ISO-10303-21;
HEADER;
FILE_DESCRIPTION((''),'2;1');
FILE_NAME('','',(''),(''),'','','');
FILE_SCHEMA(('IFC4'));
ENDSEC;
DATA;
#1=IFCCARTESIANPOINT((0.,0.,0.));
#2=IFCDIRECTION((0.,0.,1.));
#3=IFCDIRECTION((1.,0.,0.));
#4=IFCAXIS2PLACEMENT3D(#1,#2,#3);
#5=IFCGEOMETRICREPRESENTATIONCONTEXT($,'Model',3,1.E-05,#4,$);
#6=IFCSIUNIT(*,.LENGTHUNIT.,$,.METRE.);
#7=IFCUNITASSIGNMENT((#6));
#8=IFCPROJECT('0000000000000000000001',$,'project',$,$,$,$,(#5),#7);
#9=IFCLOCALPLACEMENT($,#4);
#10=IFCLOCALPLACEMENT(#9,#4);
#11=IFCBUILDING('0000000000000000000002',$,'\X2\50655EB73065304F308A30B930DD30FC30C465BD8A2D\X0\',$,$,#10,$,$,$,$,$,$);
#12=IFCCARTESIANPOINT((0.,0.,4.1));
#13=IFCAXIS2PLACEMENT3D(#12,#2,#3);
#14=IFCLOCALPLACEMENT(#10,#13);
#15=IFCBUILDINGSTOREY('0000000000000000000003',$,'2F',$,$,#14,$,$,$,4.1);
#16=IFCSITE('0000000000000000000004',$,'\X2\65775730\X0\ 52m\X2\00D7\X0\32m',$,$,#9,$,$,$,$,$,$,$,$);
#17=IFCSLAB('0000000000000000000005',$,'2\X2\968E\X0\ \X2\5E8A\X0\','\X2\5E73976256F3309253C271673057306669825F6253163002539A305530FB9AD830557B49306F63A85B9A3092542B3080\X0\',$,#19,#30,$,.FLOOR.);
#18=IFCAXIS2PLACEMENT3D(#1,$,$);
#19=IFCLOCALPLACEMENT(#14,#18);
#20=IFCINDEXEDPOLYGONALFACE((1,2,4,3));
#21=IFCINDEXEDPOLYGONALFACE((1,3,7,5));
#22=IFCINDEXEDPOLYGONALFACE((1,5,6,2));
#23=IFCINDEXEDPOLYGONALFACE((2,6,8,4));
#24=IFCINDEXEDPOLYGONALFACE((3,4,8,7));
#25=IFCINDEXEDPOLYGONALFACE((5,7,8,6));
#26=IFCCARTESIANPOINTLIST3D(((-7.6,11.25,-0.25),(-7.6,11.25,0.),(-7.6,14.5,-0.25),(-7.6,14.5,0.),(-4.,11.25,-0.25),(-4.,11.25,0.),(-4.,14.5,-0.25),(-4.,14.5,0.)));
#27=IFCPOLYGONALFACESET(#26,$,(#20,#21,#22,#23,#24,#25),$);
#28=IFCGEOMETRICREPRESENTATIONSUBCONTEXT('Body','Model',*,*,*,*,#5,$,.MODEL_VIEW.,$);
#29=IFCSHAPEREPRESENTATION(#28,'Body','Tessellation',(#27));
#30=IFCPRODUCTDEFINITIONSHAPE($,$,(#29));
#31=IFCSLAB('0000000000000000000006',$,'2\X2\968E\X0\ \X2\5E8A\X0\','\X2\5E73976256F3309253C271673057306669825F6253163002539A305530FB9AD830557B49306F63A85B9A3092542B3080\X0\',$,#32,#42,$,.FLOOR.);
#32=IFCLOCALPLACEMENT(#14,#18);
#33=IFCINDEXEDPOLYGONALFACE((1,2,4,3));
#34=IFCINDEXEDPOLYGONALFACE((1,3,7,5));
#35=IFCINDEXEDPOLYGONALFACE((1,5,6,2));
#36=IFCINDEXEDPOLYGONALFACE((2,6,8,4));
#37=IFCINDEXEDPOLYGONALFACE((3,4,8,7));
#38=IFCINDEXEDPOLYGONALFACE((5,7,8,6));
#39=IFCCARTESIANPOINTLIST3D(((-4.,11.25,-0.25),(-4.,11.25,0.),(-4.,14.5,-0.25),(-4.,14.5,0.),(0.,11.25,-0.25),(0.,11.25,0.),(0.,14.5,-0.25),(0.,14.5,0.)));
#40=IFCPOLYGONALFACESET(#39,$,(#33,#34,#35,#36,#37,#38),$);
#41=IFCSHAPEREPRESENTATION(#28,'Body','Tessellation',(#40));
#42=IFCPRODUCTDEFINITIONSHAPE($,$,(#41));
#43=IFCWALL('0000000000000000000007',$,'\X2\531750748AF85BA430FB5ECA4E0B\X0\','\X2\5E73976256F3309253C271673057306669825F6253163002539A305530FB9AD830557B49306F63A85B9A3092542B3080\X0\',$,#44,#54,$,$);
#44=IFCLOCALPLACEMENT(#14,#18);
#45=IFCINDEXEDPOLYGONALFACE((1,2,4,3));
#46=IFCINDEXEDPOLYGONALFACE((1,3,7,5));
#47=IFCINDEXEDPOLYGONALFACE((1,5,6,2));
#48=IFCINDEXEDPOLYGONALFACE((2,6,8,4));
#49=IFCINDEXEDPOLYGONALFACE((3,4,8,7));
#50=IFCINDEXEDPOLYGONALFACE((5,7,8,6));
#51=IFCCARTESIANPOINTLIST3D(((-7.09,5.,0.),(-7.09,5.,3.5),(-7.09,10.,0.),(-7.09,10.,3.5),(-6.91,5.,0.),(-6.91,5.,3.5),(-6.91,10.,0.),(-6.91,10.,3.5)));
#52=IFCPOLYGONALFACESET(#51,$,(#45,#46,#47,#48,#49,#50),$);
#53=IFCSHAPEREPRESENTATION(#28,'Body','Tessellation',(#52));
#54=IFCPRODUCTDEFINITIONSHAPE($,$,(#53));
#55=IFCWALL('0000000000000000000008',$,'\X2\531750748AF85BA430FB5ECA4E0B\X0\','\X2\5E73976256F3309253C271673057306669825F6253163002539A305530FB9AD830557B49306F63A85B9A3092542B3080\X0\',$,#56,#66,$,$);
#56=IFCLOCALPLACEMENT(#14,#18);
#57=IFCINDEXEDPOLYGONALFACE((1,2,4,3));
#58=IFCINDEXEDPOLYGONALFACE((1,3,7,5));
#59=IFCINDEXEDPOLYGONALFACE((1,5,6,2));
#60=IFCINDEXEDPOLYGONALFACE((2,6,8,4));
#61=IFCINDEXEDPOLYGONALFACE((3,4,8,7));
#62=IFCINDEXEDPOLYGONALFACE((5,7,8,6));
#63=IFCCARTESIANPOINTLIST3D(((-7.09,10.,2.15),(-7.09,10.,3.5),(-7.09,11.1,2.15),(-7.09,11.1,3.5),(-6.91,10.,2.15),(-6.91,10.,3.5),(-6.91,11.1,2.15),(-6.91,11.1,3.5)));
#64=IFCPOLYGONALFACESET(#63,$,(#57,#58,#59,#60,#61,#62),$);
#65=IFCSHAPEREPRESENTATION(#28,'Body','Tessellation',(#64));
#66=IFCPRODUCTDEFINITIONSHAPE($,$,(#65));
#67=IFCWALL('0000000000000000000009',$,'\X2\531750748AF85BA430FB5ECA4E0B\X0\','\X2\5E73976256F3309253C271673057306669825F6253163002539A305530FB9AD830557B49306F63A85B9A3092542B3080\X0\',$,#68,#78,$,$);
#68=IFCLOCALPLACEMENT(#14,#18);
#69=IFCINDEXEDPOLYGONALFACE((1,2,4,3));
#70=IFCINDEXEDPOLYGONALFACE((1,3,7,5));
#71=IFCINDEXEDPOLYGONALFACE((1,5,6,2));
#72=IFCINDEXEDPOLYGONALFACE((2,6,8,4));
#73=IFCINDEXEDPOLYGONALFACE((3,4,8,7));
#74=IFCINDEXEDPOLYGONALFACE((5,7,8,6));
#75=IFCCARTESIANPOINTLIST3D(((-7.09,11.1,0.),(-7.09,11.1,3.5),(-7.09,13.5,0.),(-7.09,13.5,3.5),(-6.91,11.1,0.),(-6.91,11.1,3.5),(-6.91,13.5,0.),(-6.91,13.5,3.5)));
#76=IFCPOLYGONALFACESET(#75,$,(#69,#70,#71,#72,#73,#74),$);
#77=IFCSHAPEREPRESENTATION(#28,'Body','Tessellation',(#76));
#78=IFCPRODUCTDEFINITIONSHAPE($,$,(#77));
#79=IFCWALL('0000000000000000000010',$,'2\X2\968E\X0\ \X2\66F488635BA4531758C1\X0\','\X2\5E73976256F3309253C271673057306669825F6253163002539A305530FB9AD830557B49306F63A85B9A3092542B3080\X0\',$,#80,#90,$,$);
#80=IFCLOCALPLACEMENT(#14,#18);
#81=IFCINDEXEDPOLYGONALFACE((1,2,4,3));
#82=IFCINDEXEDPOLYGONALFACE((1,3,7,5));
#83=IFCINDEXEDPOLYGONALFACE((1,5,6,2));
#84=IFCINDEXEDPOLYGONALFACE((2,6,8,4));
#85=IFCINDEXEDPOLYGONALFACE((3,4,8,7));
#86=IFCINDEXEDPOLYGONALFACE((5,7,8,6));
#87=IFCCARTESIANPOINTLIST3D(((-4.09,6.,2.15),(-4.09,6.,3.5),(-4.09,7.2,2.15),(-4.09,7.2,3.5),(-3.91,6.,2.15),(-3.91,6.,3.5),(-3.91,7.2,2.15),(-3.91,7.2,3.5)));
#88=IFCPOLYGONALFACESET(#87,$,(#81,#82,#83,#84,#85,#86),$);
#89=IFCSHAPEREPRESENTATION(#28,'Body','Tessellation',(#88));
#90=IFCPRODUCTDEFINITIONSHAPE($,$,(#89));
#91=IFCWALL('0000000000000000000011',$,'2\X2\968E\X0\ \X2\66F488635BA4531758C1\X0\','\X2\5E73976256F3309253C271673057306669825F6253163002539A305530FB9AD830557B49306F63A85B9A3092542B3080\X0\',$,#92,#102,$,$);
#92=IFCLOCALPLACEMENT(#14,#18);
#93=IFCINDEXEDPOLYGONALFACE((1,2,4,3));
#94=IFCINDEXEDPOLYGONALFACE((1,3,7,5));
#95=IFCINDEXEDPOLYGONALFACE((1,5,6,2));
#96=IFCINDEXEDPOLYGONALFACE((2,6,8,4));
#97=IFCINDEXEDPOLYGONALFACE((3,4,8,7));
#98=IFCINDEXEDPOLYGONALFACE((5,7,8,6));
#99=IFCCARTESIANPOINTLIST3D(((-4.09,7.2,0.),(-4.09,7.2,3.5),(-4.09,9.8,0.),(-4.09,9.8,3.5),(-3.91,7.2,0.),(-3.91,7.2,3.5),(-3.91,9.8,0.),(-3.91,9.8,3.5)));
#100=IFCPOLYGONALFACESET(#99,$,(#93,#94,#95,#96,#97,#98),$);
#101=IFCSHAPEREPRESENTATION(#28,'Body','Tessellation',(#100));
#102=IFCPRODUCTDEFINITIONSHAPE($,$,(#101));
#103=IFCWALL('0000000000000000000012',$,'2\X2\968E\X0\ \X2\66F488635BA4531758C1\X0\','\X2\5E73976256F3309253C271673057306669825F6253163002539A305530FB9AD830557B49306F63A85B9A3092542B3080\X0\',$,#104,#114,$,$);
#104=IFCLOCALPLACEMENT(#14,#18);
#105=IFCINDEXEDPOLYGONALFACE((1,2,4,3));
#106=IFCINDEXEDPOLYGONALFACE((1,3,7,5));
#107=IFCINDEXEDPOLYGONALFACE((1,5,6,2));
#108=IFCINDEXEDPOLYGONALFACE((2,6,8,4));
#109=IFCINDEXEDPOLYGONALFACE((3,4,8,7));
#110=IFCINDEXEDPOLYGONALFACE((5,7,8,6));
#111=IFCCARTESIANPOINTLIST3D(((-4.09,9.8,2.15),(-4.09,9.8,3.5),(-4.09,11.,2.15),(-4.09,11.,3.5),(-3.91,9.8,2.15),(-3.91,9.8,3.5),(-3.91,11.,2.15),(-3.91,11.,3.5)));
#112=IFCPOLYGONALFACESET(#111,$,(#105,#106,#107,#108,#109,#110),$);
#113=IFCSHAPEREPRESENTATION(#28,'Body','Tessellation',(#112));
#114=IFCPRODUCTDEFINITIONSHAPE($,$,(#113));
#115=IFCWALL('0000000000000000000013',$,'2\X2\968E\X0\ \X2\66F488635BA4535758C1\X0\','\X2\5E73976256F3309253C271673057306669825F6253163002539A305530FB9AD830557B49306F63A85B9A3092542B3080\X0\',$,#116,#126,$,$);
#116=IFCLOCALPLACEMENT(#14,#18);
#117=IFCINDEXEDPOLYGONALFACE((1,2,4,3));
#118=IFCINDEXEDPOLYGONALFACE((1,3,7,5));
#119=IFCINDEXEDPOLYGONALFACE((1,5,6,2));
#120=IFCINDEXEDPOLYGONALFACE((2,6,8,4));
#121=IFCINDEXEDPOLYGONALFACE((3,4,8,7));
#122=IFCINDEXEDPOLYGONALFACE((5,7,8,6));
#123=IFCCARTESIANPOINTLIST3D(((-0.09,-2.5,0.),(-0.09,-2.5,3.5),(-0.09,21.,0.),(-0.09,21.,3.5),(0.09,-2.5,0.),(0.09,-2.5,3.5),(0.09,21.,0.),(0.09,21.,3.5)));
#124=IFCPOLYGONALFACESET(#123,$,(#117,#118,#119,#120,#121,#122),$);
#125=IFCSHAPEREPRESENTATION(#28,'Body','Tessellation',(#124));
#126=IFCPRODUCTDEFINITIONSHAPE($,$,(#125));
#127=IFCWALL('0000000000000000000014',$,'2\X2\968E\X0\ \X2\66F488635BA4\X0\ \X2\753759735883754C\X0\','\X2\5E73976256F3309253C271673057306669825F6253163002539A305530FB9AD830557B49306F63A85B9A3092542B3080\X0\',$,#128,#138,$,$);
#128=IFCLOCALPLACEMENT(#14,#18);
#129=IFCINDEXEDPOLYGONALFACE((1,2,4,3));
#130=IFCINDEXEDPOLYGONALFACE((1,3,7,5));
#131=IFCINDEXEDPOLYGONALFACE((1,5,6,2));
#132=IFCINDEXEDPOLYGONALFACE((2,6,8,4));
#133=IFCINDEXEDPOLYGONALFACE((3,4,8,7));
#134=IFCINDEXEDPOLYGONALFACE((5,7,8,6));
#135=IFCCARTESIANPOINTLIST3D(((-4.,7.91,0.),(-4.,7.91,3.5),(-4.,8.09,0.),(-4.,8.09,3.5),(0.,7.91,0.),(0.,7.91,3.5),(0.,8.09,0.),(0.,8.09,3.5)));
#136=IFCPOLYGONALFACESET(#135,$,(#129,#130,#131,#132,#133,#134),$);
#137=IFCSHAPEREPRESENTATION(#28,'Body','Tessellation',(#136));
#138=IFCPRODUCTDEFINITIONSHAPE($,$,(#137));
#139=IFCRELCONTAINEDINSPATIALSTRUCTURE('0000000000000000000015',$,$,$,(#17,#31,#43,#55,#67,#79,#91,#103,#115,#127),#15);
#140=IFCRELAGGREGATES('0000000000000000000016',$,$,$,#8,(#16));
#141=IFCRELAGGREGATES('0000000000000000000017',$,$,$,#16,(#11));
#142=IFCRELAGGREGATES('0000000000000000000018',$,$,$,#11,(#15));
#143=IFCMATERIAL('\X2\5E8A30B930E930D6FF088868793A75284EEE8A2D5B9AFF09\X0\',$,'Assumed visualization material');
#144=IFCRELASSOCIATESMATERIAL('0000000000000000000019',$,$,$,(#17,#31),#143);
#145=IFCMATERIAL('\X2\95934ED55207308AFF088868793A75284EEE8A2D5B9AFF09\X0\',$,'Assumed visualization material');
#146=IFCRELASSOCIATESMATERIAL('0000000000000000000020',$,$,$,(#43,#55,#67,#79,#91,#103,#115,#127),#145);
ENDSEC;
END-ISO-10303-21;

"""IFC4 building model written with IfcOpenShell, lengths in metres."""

from ifc_helpers import new_model, si_unit, frame, origin_with_axes, place, context, subcontext, project, spatial, rectangle, extrude, material, element, save


model = new_model("IFC4")

# Units and contexts
model_context = context("Model", 3, precision=1e-05, world=origin_with_axes())
body_context = subcontext(model_context, "Body", "Model", "MODEL_VIEW")
ifc_project = project(units=[si_unit("LENGTHUNIT", "METRE")], contexts=[model_context])

# Site, building, storey
site_placement = place(None, origin_with_axes())
site = spatial("IfcSite", under=ifc_project, at=site_placement, Name="敷地 52m×32m")
building_placement = place(site_placement, origin_with_axes())
building = spatial("IfcBuilding", under=site, at=building_placement, Name="健康づくりスポーツ施設")
storey_placement = place(building_placement, frame((0.0, 0.0, 4.1), z_axis=(0.0, 0.0, 1.0), x_axis=(1.0, 0.0, 0.0)))
storey = spatial("IfcBuildingStorey", under=building, at=storey_placement, Name="2F", Elevation=4.1)

# Slabs
ifc_material_1 = material(Name="床スラブ（表示用仮設定）", Category="Assumed visualization material")
slab_1_placement = place(storey_placement, frame((-5.8, 12.875, -0.25), z_axis=(0.0, 0.0, 1.0), x_axis=(1.0, 0.0, 0.0)))
element("IfcSlab", 1, at=slab_1_placement, inside=storey, material=ifc_material_1, Name="2階 床", Description="平面図を参照して概形化。厚さ・高さ等は推定を含む", PredefinedType="FLOOR", context=body_context, shape_type="SweptSolid", body=[
    extrude(rectangle(XDim=3.6, YDim=3.25), origin_with_axes(), (0.0, 0.0, 1.0), 0.25),
])
slab_2_placement = place(storey_placement, frame((-2.0, 12.875, -0.25), z_axis=(0.0, 0.0, 1.0), x_axis=(1.0, 0.0, 0.0)))
element("IfcSlab", 2, at=slab_2_placement, inside=storey, material=ifc_material_1, Name="2階 床", Description="平面図を参照して概形化。厚さ・高さ等は推定を含む", PredefinedType="FLOOR", context=body_context, shape_type="SweptSolid", body=[
    extrude(rectangle(XDim=4.0, YDim=3.25), origin_with_axes(), (0.0, 0.0, 1.0), 0.25),
])

# Walls
ifc_material_2 = material(Name="間仕切り（表示用仮設定）", Category="Assumed visualization material")
wall_1_placement = place(storey_placement, frame((-7.0, 7.5, 0.0), z_axis=(0.0, 0.0, 1.0), x_axis=(1.0, 0.0, 0.0)))
element("IfcWall", 3, at=wall_1_placement, inside=storey, material=ifc_material_2, Name="北側諸室・廊下", Description="平面図を参照して概形化。厚さ・高さ等は推定を含む", context=body_context, shape_type="SweptSolid", body=[
    extrude(rectangle(XDim=0.18, YDim=5.0), origin_with_axes(), (0.0, 0.0, 1.0), 3.5),
])
wall_2_placement = place(storey_placement, frame((-7.0, 10.55, 2.15), z_axis=(0.0, 0.0, 1.0), x_axis=(1.0, 0.0, 0.0)))
element("IfcWall", 4, at=wall_2_placement, inside=storey, material=ifc_material_2, Name="北側諸室・廊下", Description="平面図を参照して概形化。厚さ・高さ等は推定を含む", context=body_context, shape_type="SweptSolid", body=[
    extrude(rectangle(XDim=0.18, YDim=1.1), origin_with_axes(), (0.0, 0.0, 1.0), 1.35),
])
wall_3_placement = place(storey_placement, frame((-7.0, 12.3, 0.0), z_axis=(0.0, 0.0, 1.0), x_axis=(1.0, 0.0, 0.0)))
element("IfcWall", 5, at=wall_3_placement, inside=storey, material=ifc_material_2, Name="北側諸室・廊下", Description="平面図を参照して概形化。厚さ・高さ等は推定を含む", context=body_context, shape_type="SweptSolid", body=[
    extrude(rectangle(XDim=0.18, YDim=2.4), origin_with_axes(), (0.0, 0.0, 1.0), 3.5),
])
wall_4_placement = place(storey_placement, frame((-4.0, 6.6, 2.15), z_axis=(0.0, 0.0, 1.0), x_axis=(1.0, 0.0, 0.0)))
element("IfcWall", 6, at=wall_4_placement, inside=storey, material=ifc_material_2, Name="2階 更衣室北壁", Description="平面図を参照して概形化。厚さ・高さ等は推定を含む", context=body_context, shape_type="SweptSolid", body=[
    extrude(rectangle(XDim=0.18, YDim=1.2), origin_with_axes(), (0.0, 0.0, 1.0), 1.35),
])
wall_5_placement = place(storey_placement, frame((-4.0, 8.5, 0.0), z_axis=(0.0, 0.0, 1.0), x_axis=(1.0, 0.0, 0.0)))
element("IfcWall", 7, at=wall_5_placement, inside=storey, material=ifc_material_2, Name="2階 更衣室北壁", Description="平面図を参照して概形化。厚さ・高さ等は推定を含む", context=body_context, shape_type="SweptSolid", body=[
    extrude(rectangle(XDim=0.18, YDim=2.6), origin_with_axes(), (0.0, 0.0, 1.0), 3.5),
])
wall_6_placement = place(storey_placement, frame((-4.0, 10.4, 2.15), z_axis=(0.0, 0.0, 1.0), x_axis=(1.0, 0.0, 0.0)))
element("IfcWall", 8, at=wall_6_placement, inside=storey, material=ifc_material_2, Name="2階 更衣室北壁", Description="平面図を参照して概形化。厚さ・高さ等は推定を含む", context=body_context, shape_type="SweptSolid", body=[
    extrude(rectangle(XDim=0.18, YDim=1.2), origin_with_axes(), (0.0, 0.0, 1.0), 1.35),
])
wall_7_placement = place(storey_placement, frame((0.0, 9.25, 0.0), z_axis=(0.0, 0.0, 1.0), x_axis=(1.0, 0.0, 0.0)))
element("IfcWall", 9, at=wall_7_placement, inside=storey, material=ifc_material_2, Name="2階 更衣室南壁", Description="平面図を参照して概形化。厚さ・高さ等は推定を含む", context=body_context, shape_type="SweptSolid", body=[
    extrude(rectangle(XDim=0.18, YDim=23.5), origin_with_axes(), (0.0, 0.0, 1.0), 3.5),
])
wall_8_placement = place(storey_placement, frame((-2.0, 8.0, 0.0), z_axis=(0.0, 0.0, 1.0), x_axis=(1.0, 0.0, 0.0)))
element("IfcWall", 10, at=wall_8_placement, inside=storey, material=ifc_material_2, Name="2階 更衣室 男女境界", Description="平面図を参照して概形化。厚さ・高さ等は推定を含む", context=body_context, shape_type="SweptSolid", body=[
    extrude(rectangle(XDim=4.0, YDim=0.18), origin_with_axes(), (0.0, 0.0, 1.0), 3.5),
])

save(model, "model.ifc")
